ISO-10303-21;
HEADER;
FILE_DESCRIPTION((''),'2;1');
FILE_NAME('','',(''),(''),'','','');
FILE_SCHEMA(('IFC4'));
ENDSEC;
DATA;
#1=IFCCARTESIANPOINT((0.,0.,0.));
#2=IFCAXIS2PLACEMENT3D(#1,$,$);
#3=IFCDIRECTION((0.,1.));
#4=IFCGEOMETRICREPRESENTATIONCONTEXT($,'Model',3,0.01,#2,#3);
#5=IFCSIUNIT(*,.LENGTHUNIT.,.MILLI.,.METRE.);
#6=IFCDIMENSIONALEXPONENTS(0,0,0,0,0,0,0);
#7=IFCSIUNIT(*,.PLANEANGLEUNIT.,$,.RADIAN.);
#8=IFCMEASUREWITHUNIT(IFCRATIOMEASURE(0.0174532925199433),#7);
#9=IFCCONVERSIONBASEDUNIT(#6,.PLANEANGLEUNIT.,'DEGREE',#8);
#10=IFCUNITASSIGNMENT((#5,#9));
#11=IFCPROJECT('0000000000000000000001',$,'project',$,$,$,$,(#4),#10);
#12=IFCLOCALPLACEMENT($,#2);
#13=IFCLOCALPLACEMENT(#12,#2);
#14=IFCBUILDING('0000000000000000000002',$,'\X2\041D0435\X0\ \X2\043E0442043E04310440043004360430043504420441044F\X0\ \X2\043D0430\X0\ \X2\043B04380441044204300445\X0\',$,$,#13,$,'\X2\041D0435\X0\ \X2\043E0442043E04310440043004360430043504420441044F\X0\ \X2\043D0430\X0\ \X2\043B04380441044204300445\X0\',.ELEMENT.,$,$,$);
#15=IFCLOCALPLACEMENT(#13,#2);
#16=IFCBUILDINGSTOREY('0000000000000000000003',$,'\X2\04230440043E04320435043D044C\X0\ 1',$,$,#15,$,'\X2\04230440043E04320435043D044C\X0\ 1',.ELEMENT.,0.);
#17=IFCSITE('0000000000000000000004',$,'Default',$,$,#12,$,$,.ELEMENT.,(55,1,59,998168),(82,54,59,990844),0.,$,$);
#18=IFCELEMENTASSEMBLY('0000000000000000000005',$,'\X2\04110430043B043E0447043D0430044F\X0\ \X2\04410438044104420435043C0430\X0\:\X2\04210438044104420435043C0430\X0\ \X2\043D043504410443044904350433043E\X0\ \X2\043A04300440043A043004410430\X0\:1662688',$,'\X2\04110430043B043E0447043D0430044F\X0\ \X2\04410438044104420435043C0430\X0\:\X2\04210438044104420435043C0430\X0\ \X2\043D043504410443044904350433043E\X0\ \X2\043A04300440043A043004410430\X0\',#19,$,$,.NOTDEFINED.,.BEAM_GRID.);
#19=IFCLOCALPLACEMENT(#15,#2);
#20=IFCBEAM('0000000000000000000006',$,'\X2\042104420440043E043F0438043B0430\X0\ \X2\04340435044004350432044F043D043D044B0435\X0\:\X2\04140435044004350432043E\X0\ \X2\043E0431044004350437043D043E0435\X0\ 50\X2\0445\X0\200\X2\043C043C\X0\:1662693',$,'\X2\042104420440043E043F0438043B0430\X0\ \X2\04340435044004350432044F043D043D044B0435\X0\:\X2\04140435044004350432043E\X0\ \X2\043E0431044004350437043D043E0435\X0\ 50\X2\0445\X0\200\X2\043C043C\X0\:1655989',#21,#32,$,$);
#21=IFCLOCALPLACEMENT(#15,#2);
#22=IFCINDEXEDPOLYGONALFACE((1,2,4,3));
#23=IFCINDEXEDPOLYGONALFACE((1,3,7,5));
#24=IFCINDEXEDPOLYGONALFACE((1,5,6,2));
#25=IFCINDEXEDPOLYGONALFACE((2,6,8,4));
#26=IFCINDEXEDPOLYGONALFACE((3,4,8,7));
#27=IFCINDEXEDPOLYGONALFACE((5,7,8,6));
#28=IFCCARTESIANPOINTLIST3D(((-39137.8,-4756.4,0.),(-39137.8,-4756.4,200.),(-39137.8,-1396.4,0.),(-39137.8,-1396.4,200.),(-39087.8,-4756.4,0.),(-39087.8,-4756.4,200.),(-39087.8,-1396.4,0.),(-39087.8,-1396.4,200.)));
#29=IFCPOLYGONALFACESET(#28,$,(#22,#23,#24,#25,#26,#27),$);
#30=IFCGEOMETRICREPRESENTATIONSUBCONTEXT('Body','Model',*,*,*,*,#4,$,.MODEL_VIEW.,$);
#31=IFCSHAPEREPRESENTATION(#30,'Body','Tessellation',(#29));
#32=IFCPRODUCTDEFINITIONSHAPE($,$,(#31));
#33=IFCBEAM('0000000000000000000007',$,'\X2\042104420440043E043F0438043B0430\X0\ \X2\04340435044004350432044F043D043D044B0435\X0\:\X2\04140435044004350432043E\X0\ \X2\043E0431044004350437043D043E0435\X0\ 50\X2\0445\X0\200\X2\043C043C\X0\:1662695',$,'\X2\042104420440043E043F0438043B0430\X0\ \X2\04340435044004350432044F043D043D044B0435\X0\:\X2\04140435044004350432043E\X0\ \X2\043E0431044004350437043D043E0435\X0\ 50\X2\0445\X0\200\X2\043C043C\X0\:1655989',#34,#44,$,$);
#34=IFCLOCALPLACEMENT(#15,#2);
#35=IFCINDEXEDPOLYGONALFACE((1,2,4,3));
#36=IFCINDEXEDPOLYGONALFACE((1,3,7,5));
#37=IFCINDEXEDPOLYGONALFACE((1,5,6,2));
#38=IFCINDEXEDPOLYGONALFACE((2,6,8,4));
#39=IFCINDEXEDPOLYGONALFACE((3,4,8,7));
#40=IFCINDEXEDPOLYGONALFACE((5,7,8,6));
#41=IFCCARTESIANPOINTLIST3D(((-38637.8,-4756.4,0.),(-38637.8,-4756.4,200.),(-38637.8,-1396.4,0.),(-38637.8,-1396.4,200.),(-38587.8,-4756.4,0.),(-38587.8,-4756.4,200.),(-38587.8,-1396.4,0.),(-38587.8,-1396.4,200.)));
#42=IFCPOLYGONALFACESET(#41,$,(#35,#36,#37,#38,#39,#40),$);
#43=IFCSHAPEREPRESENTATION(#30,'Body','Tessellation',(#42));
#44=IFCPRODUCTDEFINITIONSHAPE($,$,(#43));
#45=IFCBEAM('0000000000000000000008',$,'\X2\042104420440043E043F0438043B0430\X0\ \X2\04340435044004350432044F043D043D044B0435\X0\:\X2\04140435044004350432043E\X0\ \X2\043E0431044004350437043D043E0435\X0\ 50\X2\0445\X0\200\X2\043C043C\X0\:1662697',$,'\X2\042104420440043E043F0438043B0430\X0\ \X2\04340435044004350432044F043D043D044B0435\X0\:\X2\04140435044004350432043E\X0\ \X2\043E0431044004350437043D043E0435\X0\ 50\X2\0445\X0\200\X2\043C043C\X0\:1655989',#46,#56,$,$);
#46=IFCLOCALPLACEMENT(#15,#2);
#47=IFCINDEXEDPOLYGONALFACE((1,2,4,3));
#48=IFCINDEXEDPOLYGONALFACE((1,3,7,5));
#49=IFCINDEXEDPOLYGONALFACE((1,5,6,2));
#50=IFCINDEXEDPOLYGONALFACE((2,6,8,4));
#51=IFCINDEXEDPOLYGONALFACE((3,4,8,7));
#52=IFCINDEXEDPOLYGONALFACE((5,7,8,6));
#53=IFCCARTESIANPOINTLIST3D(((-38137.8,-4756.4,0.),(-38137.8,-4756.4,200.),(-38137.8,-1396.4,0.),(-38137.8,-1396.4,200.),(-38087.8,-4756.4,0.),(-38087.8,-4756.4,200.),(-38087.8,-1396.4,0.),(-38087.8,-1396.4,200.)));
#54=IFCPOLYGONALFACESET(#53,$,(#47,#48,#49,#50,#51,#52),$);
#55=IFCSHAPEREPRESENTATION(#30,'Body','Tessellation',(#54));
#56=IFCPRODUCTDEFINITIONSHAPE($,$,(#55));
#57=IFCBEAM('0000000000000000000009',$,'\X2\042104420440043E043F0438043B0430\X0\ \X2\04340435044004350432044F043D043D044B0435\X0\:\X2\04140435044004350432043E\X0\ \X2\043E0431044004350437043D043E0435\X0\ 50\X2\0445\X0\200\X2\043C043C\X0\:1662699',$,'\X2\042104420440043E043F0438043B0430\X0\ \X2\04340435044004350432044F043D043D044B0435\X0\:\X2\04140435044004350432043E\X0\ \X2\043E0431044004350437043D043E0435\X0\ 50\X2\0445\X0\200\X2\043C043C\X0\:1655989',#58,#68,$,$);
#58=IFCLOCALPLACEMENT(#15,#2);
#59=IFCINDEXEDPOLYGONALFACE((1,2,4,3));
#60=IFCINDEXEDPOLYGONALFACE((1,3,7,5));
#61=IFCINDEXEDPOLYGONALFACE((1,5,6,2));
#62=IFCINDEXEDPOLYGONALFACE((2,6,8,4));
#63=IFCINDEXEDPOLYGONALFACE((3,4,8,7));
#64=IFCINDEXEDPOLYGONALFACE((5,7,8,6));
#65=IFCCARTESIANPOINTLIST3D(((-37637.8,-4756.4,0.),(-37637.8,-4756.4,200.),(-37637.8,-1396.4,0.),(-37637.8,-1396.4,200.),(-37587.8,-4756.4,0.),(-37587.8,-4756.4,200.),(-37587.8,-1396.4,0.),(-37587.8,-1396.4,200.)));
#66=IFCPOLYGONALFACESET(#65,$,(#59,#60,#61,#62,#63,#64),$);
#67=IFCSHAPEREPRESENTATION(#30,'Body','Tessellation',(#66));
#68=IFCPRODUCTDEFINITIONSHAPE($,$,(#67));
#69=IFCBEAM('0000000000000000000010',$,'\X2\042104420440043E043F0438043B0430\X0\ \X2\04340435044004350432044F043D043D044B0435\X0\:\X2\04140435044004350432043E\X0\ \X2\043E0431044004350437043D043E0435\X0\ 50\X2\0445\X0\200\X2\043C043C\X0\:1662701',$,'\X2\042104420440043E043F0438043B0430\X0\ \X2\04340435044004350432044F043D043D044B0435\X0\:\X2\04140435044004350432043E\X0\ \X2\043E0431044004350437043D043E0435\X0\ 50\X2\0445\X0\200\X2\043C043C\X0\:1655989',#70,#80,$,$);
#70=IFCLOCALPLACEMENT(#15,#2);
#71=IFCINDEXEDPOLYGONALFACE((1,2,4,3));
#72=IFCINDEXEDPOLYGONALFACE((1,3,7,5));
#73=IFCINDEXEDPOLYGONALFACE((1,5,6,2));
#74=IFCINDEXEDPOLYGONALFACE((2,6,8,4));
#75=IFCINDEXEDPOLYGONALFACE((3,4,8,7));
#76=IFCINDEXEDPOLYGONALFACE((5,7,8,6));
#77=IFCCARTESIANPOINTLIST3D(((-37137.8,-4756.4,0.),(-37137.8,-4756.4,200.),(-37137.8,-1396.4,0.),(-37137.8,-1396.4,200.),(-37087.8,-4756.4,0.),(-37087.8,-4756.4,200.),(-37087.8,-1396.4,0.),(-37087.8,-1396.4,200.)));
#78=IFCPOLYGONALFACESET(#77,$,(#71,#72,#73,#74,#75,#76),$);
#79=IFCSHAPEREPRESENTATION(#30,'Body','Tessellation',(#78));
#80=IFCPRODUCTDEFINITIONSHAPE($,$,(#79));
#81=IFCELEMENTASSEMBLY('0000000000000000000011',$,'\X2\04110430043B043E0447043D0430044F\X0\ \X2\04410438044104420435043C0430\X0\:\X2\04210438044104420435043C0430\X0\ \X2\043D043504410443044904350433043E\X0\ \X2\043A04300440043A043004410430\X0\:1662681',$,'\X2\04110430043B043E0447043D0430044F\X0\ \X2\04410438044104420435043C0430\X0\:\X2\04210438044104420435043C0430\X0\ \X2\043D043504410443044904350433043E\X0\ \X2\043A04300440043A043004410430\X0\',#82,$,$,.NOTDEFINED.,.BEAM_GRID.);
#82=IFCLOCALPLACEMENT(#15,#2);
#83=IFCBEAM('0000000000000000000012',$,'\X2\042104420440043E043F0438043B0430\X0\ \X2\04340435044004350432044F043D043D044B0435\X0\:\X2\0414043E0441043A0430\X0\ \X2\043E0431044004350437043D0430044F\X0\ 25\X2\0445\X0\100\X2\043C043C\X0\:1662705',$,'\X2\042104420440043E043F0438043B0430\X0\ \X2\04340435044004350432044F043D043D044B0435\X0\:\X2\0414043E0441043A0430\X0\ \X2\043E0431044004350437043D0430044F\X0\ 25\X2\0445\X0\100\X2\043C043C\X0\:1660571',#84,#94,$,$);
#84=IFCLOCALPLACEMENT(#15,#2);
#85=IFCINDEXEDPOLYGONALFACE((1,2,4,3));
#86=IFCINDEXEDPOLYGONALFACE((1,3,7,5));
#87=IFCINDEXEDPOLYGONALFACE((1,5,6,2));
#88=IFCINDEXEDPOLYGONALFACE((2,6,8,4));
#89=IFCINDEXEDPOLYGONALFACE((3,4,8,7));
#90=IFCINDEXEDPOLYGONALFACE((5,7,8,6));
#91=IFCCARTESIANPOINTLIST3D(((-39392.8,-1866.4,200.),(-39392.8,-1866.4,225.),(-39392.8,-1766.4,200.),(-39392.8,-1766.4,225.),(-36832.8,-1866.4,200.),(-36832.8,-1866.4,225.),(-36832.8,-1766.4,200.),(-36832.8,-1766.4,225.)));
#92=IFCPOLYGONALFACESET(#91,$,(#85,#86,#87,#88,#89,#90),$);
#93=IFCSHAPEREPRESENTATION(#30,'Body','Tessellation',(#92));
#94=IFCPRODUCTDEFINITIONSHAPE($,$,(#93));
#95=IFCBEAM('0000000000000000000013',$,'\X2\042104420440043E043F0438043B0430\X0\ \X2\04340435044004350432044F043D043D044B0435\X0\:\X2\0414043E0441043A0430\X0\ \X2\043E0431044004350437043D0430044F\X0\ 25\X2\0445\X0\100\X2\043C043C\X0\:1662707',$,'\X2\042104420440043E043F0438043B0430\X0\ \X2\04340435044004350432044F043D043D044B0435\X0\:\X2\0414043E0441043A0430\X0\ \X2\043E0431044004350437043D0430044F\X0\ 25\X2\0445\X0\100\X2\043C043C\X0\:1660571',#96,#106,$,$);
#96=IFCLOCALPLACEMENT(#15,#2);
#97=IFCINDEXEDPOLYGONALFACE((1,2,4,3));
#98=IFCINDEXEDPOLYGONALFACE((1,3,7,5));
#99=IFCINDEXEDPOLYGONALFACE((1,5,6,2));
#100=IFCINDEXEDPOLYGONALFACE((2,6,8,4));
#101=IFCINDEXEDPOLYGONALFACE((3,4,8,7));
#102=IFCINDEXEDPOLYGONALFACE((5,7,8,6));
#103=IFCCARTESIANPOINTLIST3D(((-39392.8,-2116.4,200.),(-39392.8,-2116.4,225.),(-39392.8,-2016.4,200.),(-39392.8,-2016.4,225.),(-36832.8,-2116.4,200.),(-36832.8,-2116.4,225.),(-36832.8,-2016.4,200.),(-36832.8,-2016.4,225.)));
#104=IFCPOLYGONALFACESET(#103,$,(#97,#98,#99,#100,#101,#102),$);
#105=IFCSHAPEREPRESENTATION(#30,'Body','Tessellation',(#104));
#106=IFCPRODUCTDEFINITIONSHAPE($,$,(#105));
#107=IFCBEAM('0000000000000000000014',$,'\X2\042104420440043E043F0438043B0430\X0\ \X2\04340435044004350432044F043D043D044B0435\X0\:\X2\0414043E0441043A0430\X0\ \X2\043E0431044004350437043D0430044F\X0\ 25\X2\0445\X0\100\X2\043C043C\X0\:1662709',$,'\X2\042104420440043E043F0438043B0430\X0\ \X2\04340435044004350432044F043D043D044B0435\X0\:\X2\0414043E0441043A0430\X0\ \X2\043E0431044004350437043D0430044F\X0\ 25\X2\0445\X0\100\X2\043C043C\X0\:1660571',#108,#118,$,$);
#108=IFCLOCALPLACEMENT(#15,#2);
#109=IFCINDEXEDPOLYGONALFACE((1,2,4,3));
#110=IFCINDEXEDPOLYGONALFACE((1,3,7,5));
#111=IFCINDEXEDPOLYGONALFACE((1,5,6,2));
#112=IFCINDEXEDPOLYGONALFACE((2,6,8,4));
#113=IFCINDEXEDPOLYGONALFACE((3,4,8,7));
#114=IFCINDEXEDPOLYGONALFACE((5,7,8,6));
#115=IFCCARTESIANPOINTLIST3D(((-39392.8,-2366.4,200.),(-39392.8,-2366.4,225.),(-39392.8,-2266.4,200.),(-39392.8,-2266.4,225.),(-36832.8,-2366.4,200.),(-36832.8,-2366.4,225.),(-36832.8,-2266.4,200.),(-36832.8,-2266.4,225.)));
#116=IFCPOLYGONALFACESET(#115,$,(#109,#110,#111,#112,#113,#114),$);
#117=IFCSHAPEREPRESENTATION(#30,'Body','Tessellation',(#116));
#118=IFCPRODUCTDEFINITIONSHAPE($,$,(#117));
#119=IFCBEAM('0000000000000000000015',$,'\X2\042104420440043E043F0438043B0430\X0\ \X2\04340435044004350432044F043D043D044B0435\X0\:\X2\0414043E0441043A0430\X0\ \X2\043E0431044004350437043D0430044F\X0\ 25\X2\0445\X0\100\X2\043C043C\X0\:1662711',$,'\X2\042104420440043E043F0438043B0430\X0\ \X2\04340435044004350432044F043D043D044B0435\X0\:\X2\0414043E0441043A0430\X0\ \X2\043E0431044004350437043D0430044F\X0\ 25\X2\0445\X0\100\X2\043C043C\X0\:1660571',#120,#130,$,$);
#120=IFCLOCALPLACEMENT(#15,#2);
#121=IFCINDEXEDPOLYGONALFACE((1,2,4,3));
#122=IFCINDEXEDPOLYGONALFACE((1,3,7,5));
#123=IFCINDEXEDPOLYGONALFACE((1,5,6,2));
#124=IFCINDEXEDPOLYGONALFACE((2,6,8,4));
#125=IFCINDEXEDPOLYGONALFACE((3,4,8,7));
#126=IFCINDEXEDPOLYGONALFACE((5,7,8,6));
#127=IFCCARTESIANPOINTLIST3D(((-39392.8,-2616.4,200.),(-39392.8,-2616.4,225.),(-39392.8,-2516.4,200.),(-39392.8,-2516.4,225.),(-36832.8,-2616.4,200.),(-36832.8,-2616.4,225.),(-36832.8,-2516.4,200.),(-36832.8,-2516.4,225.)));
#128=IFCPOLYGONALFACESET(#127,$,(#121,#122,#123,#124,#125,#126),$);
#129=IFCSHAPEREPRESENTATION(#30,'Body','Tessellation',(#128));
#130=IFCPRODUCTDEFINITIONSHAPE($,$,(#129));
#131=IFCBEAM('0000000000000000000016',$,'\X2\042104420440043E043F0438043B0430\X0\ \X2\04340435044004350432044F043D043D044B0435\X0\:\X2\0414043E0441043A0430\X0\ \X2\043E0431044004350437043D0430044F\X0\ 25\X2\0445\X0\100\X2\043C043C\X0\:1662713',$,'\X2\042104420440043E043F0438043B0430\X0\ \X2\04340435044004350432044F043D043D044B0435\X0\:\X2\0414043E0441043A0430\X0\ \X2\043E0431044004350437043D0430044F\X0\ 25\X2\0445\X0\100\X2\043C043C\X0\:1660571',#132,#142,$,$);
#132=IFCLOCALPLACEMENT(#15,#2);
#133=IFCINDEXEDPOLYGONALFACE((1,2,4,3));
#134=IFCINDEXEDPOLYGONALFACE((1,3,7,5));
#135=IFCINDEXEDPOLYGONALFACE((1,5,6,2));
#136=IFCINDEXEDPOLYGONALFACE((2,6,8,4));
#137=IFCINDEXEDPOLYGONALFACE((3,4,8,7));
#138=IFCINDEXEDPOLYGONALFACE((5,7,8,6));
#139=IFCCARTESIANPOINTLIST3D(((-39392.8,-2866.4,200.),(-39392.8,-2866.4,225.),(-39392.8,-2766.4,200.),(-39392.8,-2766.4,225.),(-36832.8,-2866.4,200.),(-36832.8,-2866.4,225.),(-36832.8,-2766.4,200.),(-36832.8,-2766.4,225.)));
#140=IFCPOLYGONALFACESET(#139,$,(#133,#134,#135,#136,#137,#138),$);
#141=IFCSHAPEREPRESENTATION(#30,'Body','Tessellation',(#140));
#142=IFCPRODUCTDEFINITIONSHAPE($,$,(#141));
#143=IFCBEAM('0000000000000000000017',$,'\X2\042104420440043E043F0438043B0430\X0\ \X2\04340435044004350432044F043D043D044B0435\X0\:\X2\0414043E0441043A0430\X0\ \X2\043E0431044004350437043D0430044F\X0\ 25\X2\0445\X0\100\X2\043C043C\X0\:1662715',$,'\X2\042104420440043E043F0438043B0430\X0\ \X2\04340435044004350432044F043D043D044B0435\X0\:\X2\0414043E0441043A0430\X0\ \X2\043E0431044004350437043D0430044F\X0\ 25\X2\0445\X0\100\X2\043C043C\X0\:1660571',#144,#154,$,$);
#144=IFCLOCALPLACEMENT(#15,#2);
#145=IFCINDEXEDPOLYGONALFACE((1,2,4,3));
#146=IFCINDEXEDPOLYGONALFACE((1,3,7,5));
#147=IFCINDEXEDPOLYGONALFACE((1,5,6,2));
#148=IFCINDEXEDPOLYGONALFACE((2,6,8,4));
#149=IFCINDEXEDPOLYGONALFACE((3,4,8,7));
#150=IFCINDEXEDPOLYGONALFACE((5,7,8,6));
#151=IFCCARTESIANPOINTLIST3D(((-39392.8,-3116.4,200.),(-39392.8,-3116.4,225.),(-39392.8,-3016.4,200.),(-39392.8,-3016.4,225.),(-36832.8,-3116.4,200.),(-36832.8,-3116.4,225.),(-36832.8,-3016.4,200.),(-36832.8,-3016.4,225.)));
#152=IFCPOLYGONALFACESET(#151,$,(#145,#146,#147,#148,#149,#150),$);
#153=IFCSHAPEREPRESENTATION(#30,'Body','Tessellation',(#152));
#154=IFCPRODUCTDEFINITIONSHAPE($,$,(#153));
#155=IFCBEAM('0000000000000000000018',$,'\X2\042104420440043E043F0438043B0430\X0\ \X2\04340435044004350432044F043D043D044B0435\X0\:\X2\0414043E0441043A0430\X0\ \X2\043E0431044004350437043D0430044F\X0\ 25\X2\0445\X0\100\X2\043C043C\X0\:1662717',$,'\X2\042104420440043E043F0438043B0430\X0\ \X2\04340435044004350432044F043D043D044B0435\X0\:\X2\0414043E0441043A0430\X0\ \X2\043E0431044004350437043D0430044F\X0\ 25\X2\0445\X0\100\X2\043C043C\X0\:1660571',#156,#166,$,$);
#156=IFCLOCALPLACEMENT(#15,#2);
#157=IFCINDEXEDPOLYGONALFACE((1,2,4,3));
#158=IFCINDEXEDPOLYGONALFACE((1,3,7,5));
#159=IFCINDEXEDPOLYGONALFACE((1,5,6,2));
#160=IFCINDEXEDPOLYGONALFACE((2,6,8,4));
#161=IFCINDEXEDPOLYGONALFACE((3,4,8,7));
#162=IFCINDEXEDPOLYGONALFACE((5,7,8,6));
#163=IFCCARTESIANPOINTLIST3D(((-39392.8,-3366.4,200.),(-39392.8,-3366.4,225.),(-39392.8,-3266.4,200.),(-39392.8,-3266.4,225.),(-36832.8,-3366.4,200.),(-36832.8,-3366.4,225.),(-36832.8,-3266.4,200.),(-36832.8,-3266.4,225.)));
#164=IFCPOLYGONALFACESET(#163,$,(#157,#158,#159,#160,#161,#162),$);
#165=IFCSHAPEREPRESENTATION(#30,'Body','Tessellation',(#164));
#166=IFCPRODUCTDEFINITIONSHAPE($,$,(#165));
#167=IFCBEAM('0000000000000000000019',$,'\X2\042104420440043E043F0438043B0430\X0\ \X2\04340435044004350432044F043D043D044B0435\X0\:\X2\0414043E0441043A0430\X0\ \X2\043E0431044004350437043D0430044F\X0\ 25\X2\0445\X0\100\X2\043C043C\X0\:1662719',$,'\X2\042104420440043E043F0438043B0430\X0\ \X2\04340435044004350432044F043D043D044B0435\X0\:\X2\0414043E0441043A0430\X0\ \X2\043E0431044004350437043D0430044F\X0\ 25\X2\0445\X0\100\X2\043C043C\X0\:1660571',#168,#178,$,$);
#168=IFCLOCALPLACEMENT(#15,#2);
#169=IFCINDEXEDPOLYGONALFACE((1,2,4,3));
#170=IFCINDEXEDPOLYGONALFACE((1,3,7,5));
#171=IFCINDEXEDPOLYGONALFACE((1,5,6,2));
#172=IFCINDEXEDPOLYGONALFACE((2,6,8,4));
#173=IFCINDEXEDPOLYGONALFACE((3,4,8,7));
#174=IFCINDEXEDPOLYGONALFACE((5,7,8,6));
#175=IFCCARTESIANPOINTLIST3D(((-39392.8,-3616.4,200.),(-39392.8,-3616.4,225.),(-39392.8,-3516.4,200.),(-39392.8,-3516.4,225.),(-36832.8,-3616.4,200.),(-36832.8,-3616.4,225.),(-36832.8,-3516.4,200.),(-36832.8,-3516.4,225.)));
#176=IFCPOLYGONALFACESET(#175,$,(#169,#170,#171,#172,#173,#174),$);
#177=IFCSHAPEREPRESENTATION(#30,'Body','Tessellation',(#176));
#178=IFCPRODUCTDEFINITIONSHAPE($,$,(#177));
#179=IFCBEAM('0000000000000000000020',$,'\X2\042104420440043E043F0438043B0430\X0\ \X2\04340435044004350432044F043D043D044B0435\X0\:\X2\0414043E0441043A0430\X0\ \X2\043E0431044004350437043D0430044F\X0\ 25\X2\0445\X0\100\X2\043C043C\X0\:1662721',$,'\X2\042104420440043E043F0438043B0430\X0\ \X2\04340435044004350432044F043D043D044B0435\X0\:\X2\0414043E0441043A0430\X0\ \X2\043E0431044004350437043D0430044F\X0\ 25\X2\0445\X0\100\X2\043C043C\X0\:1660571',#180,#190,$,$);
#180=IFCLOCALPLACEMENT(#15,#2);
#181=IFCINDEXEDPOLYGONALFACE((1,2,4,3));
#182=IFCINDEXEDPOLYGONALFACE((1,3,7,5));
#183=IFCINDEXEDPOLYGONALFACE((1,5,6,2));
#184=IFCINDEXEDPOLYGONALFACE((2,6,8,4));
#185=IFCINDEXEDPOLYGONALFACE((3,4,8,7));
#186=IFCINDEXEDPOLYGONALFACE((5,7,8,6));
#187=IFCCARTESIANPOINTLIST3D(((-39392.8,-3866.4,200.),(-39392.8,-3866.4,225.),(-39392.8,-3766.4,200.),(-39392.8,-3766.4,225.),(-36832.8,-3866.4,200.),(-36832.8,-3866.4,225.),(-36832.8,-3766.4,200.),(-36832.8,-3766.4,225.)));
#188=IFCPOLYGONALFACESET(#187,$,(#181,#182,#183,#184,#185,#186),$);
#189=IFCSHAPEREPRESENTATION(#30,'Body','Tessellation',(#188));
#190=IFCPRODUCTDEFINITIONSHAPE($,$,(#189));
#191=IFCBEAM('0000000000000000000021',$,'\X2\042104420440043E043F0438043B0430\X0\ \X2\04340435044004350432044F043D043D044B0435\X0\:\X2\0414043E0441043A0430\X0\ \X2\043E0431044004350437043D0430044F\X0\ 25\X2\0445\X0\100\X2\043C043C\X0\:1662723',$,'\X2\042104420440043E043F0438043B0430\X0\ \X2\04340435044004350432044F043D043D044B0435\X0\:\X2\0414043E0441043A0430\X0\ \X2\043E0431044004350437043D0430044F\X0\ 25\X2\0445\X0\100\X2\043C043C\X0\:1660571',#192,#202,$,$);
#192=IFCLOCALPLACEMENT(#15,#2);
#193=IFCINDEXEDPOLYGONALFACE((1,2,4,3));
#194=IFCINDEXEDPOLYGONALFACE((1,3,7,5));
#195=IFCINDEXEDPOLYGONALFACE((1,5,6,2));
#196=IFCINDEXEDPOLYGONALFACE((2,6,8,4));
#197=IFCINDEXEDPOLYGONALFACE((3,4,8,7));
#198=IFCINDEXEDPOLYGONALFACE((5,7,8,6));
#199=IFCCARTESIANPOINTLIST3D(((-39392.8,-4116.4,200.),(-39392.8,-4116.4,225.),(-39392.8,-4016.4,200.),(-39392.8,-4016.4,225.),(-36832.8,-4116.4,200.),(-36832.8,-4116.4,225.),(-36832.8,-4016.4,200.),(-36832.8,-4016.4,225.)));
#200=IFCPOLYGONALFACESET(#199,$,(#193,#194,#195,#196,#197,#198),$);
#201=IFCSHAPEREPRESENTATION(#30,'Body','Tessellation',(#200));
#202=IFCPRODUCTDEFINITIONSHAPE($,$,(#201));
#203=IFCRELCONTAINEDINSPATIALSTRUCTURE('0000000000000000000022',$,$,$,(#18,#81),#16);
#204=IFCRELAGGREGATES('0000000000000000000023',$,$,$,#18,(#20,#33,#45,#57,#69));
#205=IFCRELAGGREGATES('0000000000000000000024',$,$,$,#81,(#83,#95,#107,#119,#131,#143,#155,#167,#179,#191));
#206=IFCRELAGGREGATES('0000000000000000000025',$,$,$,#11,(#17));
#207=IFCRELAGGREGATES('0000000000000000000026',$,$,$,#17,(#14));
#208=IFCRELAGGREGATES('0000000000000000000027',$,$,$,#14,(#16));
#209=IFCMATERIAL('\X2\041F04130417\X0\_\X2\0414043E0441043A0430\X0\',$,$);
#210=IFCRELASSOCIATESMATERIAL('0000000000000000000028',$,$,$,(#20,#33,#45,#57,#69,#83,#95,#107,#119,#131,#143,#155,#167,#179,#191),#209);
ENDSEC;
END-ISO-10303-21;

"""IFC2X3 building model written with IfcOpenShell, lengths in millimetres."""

from ifc_helpers import new_model, entity, si_unit, converted_unit, direction, frame, frame_2d, origin, origin_2d_with_axis, place, context, subcontext, project, spatial, rectangle, extrude, material, element, aggregate, save


model = new_model("IFC2X3")

# Units and contexts
model_context = context("Model", 3, precision=0.01, world=origin(), true_north=direction((0.0, 1.0)))
body_context = subcontext(model_context, "Body", "Model", "MODEL_VIEW")
ifc_project = project(units=[si_unit("LENGTHUNIT", "METRE", prefix="MILLI"), converted_unit("PLANEANGLEUNIT", "DEGREE", entity("IfcRatioMeasure", 0.0174532925199433), si_unit("PLANEANGLEUNIT", "RADIAN"), dimensions=[0, 0, 0, 0, 0, 0, 0])], contexts=[model_context])

# Site, building, storey
site_placement = place(None, origin())
site = spatial("IfcSite", under=ifc_project, at=site_placement, Name="Default", CompositionType="ELEMENT", RefLatitude=(55, 1, 59, 998168), RefLongitude=(82, 54, 59, 990844), RefElevation=0.0)
building_placement = place(site_placement, origin())
building = spatial("IfcBuilding", under=site, at=building_placement, Name="Не отображается на листах", LongName="Не отображается на листах", CompositionType="ELEMENT")
storey_placement = place(building_placement, frame((0.0, 0.0, 0.0)))
storey = spatial("IfcBuildingStorey", under=building, at=storey_placement, Name="Уровень 1", LongName="Уровень 1", CompositionType="ELEMENT", Elevation=0.0)

# Element assemblies, beams
assembly_1_placement = place(storey_placement, origin())
assembly_1 = element("IfcElementAssembly", 1, at=assembly_1_placement, inside=storey, Name="Балочная система:Система несущего каркаса:1662688", ObjectType="Балочная система:Система несущего каркаса", AssemblyPlace="NOTDEFINED", PredefinedType="BEAM_GRID")
ifc_material_1 = material(Name="ПГЗ_Доска")
beam_1_placement = place(assembly_1_placement, frame((-39112.8, -4756.4, 0.0), z_axis=(0.0, 0.0, 1.0), x_axis=(0.0, 1.0, 0.0)))
beam_1 = element("IfcBeam", 2, at=beam_1_placement, material=ifc_material_1, Name="Стропила деревянные:Дерево обрезное 50х200мм:1662693", ObjectType="Стропила деревянные:Дерево обрезное 50х200мм:1655989", context=body_context, shape_type="SweptSolid", body=[
    extrude(rectangle(XDim=200.0, YDim=50.0, at=frame_2d((0.0, 0.0), x_axis=(1.0, 0.0))), frame((0.0, 0.0, 100.0), z_axis=(1.0, 0.0, 0.0), x_axis=(0.0, 0.0, -1.0)), (0.0, 0.0, 1.0), 3360.0),
])
beam_2_placement = place(assembly_1_placement, frame((-38612.8, -4756.4, 0.0), z_axis=(0.0, 0.0, 1.0), x_axis=(0.0, 1.0, 0.0)))
beam_2 = element("IfcBeam", 3, at=beam_2_placement, material=ifc_material_1, Name="Стропила деревянные:Дерево обрезное 50х200мм:1662695", ObjectType="Стропила деревянные:Дерево обрезное 50х200мм:1655989", context=body_context, shape_type="SweptSolid", body=[
    extrude(rectangle(XDim=200.0, YDim=50.0, at=frame_2d((0.0, 0.0), x_axis=(1.0, 0.0))), frame((0.0, 0.0, 100.0), z_axis=(1.0, 0.0, 0.0), x_axis=(0.0, 0.0, -1.0)), (0.0, 0.0, 1.0), 3360.0),
])
beam_3_placement = place(assembly_1_placement, frame((-38112.8, -4756.4, 0.0), z_axis=(0.0, 0.0, 1.0), x_axis=(0.0, 1.0, 0.0)))
beam_3 = element("IfcBeam", 4, at=beam_3_placement, material=ifc_material_1, Name="Стропила деревянные:Дерево обрезное 50х200мм:1662697", ObjectType="Стропила деревянные:Дерево обрезное 50х200мм:1655989", context=body_context, shape_type="SweptSolid", body=[
    extrude(rectangle(XDim=200.0, YDim=50.0, at=frame_2d((0.0, 0.0), x_axis=(1.0, 0.0))), frame((0.0, 0.0, 100.0), z_axis=(1.0, 0.0, 0.0), x_axis=(0.0, 0.0, -1.0)), (0.0, 0.0, 1.0), 3360.0),
])
beam_4_placement = place(assembly_1_placement, frame((-37612.8, -4756.4, 0.0), z_axis=(0.0, 0.0, 1.0), x_axis=(0.0, 1.0, 0.0)))
beam_4 = element("IfcBeam", 5, at=beam_4_placement, material=ifc_material_1, Name="Стропила деревянные:Дерево обрезное 50х200мм:1662699", ObjectType="Стропила деревянные:Дерево обрезное 50х200мм:1655989", context=body_context, shape_type="SweptSolid", body=[
    extrude(rectangle(XDim=200.0, YDim=50.0, at=frame_2d((0.0, 0.0), x_axis=(1.0, 0.0))), frame((0.0, 0.0, 100.0), z_axis=(1.0, 0.0, 0.0), x_axis=(0.0, 0.0, -1.0)), (0.0, 0.0, 1.0), 3360.0),
])
beam_5_placement = place(assembly_1_placement, frame((-37112.8, -4756.4, 0.0), z_axis=(0.0, 0.0, 1.0), x_axis=(0.0, 1.0, 0.0)))
beam_5 = element("IfcBeam", 6, at=beam_5_placement, material=ifc_material_1, Name="Стропила деревянные:Дерево обрезное 50х200мм:1662701", ObjectType="Стропила деревянные:Дерево обрезное 50х200мм:1655989", context=body_context, shape_type="SweptSolid", body=[
    extrude(rectangle(XDim=200.0, YDim=50.0, at=frame_2d((0.0, 0.0), x_axis=(1.0, 0.0))), frame((0.0, 0.0, 100.0), z_axis=(1.0, 0.0, 0.0), x_axis=(0.0, 0.0, -1.0)), (0.0, 0.0, 1.0), 3360.0),
])
aggregate(assembly_1, [beam_1, beam_2, beam_3, beam_4, beam_5])
assembly_2_placement = place(storey_placement, origin())
assembly_2 = element("IfcElementAssembly", 7, at=assembly_2_placement, inside=storey, Name="Балочная система:Система несущего каркаса:1662681", ObjectType="Балочная система:Система несущего каркаса", AssemblyPlace="NOTDEFINED", PredefinedType="BEAM_GRID")
beam_6_placement = place(assembly_2_placement, frame((-39392.8, -1816.4, 0.0)))
beam_6 = element("IfcBeam", 8, at=beam_6_placement, material=ifc_material_1, Name="Стропила деревянные:Доска обрезная 25х100мм:1662705", ObjectType="Стропила деревянные:Доска обрезная 25х100мм:1660571", context=body_context, shape_type="SweptSolid", body=[
    extrude(rectangle(XDim=25.0, YDim=100.0, at=origin_2d_with_axis()), frame((0.0, 0.0, 212.5), z_axis=(1.0, 0.0, 0.0), x_axis=(0.0, 0.0, -1.0)), (0.0, 0.0, 1.0), 2560.0),
])
beam_7_placement = place(assembly_2_placement, frame((-39392.8, -2066.4, 0.0)))
beam_7 = element("IfcBeam", 9, at=beam_7_placement, material=ifc_material_1, Name="Стропила деревянные:Доска обрезная 25х100мм:1662707", ObjectType="Стропила деревянные:Доска обрезная 25х100мм:1660571", context=body_context, shape_type="SweptSolid", body=[
    extrude(rectangle(XDim=25.0, YDim=100.0, at=origin_2d_with_axis()), frame((0.0, 0.0, 212.5), z_axis=(1.0, 0.0, 0.0), x_axis=(0.0, 0.0, -1.0)), (0.0, 0.0, 1.0), 2560.0),
])
beam_8_placement = place(assembly_2_placement, frame((-39392.8, -2316.4, 0.0)))
beam_8 = element("IfcBeam", 10, at=beam_8_placement, material=ifc_material_1, Name="Стропила деревянные:Доска обрезная 25х100мм:1662709", ObjectType="Стропила деревянные:Доска обрезная 25х100мм:1660571", context=body_context, shape_type="SweptSolid", body=[
    extrude(rectangle(XDim=25.0, YDim=100.0, at=origin_2d_with_axis()), frame((0.0, 0.0, 212.5), z_axis=(1.0, 0.0, 0.0), x_axis=(0.0, 0.0, -1.0)), (0.0, 0.0, 1.0), 2560.0),
])
beam_9_placement = place(assembly_2_placement, frame((-39392.8, -2566.4, 0.0)))
beam_9 = element("IfcBeam", 11, at=beam_9_placement, material=ifc_material_1, Name="Стропила деревянные:Доска обрезная 25х100мм:1662711", ObjectType="Стропила деревянные:Доска обрезная 25х100мм:1660571", context=body_context, shape_type="SweptSolid", body=[
    extrude(rectangle(XDim=25.0, YDim=100.0, at=origin_2d_with_axis()), frame((0.0, 0.0, 212.5), z_axis=(1.0, 0.0, 0.0), x_axis=(0.0, 0.0, -1.0)), (0.0, 0.0, 1.0), 2560.0),
])
beam_10_placement = place(assembly_2_placement, frame((-39392.8, -2816.4, 0.0)))
beam_10 = element("IfcBeam", 12, at=beam_10_placement, material=ifc_material_1, Name="Стропила деревянные:Доска обрезная 25х100мм:1662713", ObjectType="Стропила деревянные:Доска обрезная 25х100мм:1660571", context=body_context, shape_type="SweptSolid", body=[
    extrude(rectangle(XDim=25.0, YDim=100.0, at=origin_2d_with_axis()), frame((0.0, 0.0, 212.5), z_axis=(1.0, 0.0, 0.0), x_axis=(0.0, 0.0, -1.0)), (0.0, 0.0, 1.0), 2560.0),
])
beam_11_placement = place(assembly_2_placement, frame((-39392.8, -3066.4, 0.0)))
beam_11 = element("IfcBeam", 13, at=beam_11_placement, material=ifc_material_1, Name="Стропила деревянные:Доска обрезная 25х100мм:1662715", ObjectType="Стропила деревянные:Доска обрезная 25х100мм:1660571", context=body_context, shape_type="SweptSolid", body=[
    extrude(rectangle(XDim=25.0, YDim=100.0, at=origin_2d_with_axis()), frame((0.0, 0.0, 212.5), z_axis=(1.0, 0.0, 0.0), x_axis=(0.0, 0.0, -1.0)), (0.0, 0.0, 1.0), 2560.0),
])
beam_12_placement = place(assembly_2_placement, frame((-39392.8, -3316.4, 0.0)))
beam_12 = element("IfcBeam", 14, at=beam_12_placement, material=ifc_material_1, Name="Стропила деревянные:Доска обрезная 25х100мм:1662717", ObjectType="Стропила деревянные:Доска обрезная 25х100мм:1660571", context=body_context, shape_type="SweptSolid", body=[
    extrude(rectangle(XDim=25.0, YDim=100.0, at=origin_2d_with_axis()), frame((0.0, 0.0, 212.5), z_axis=(1.0, 0.0, 0.0), x_axis=(0.0, 0.0, -1.0)), (0.0, 0.0, 1.0), 2560.0),
])
beam_13_placement = place(assembly_2_placement, frame((-39392.8, -3566.4, 0.0)))
beam_13 = element("IfcBeam", 15, at=beam_13_placement, material=ifc_material_1, Name="Стропила деревянные:Доска обрезная 25х100мм:1662719", ObjectType="Стропила деревянные:Доска обрезная 25х100мм:1660571", context=body_context, shape_type="SweptSolid", body=[
    extrude(rectangle(XDim=25.0, YDim=100.0, at=origin_2d_with_axis()), frame((0.0, 0.0, 212.5), z_axis=(1.0, 0.0, 0.0), x_axis=(0.0, 0.0, -1.0)), (0.0, 0.0, 1.0), 2560.0),
])
beam_14_placement = place(assembly_2_placement, frame((-39392.8, -3816.4, 0.0)))
beam_14 = element("IfcBeam", 16, at=beam_14_placement, material=ifc_material_1, Name="Стропила деревянные:Доска обрезная 25х100мм:1662721", ObjectType="Стропила деревянные:Доска обрезная 25х100мм:1660571", context=body_context, shape_type="SweptSolid", body=[
    extrude(rectangle(XDim=25.0, YDim=100.0, at=origin_2d_with_axis()), frame((0.0, 0.0, 212.5), z_axis=(1.0, 0.0, 0.0), x_axis=(0.0, 0.0, -1.0)), (0.0, 0.0, 1.0), 2560.0),
])
beam_15_placement = place(assembly_2_placement, frame((-39392.8, -4066.4, 0.0)))
beam_15 = element("IfcBeam", 17, at=beam_15_placement, material=ifc_material_1, Name="Стропила деревянные:Доска обрезная 25х100мм:1662723", ObjectType="Стропила деревянные:Доска обрезная 25х100мм:1660571", context=body_context, shape_type="SweptSolid", body=[
    extrude(rectangle(XDim=25.0, YDim=100.0, at=origin_2d_with_axis()), frame((0.0, 0.0, 212.5), z_axis=(1.0, 0.0, 0.0), x_axis=(0.0, 0.0, -1.0)), (0.0, 0.0, 1.0), 2560.0),
])
aggregate(assembly_2, [beam_6, beam_7, beam_8, beam_9, beam_10, beam_11, beam_12, beam_13, beam_14, beam_15])

save(model, "model.ifc")
